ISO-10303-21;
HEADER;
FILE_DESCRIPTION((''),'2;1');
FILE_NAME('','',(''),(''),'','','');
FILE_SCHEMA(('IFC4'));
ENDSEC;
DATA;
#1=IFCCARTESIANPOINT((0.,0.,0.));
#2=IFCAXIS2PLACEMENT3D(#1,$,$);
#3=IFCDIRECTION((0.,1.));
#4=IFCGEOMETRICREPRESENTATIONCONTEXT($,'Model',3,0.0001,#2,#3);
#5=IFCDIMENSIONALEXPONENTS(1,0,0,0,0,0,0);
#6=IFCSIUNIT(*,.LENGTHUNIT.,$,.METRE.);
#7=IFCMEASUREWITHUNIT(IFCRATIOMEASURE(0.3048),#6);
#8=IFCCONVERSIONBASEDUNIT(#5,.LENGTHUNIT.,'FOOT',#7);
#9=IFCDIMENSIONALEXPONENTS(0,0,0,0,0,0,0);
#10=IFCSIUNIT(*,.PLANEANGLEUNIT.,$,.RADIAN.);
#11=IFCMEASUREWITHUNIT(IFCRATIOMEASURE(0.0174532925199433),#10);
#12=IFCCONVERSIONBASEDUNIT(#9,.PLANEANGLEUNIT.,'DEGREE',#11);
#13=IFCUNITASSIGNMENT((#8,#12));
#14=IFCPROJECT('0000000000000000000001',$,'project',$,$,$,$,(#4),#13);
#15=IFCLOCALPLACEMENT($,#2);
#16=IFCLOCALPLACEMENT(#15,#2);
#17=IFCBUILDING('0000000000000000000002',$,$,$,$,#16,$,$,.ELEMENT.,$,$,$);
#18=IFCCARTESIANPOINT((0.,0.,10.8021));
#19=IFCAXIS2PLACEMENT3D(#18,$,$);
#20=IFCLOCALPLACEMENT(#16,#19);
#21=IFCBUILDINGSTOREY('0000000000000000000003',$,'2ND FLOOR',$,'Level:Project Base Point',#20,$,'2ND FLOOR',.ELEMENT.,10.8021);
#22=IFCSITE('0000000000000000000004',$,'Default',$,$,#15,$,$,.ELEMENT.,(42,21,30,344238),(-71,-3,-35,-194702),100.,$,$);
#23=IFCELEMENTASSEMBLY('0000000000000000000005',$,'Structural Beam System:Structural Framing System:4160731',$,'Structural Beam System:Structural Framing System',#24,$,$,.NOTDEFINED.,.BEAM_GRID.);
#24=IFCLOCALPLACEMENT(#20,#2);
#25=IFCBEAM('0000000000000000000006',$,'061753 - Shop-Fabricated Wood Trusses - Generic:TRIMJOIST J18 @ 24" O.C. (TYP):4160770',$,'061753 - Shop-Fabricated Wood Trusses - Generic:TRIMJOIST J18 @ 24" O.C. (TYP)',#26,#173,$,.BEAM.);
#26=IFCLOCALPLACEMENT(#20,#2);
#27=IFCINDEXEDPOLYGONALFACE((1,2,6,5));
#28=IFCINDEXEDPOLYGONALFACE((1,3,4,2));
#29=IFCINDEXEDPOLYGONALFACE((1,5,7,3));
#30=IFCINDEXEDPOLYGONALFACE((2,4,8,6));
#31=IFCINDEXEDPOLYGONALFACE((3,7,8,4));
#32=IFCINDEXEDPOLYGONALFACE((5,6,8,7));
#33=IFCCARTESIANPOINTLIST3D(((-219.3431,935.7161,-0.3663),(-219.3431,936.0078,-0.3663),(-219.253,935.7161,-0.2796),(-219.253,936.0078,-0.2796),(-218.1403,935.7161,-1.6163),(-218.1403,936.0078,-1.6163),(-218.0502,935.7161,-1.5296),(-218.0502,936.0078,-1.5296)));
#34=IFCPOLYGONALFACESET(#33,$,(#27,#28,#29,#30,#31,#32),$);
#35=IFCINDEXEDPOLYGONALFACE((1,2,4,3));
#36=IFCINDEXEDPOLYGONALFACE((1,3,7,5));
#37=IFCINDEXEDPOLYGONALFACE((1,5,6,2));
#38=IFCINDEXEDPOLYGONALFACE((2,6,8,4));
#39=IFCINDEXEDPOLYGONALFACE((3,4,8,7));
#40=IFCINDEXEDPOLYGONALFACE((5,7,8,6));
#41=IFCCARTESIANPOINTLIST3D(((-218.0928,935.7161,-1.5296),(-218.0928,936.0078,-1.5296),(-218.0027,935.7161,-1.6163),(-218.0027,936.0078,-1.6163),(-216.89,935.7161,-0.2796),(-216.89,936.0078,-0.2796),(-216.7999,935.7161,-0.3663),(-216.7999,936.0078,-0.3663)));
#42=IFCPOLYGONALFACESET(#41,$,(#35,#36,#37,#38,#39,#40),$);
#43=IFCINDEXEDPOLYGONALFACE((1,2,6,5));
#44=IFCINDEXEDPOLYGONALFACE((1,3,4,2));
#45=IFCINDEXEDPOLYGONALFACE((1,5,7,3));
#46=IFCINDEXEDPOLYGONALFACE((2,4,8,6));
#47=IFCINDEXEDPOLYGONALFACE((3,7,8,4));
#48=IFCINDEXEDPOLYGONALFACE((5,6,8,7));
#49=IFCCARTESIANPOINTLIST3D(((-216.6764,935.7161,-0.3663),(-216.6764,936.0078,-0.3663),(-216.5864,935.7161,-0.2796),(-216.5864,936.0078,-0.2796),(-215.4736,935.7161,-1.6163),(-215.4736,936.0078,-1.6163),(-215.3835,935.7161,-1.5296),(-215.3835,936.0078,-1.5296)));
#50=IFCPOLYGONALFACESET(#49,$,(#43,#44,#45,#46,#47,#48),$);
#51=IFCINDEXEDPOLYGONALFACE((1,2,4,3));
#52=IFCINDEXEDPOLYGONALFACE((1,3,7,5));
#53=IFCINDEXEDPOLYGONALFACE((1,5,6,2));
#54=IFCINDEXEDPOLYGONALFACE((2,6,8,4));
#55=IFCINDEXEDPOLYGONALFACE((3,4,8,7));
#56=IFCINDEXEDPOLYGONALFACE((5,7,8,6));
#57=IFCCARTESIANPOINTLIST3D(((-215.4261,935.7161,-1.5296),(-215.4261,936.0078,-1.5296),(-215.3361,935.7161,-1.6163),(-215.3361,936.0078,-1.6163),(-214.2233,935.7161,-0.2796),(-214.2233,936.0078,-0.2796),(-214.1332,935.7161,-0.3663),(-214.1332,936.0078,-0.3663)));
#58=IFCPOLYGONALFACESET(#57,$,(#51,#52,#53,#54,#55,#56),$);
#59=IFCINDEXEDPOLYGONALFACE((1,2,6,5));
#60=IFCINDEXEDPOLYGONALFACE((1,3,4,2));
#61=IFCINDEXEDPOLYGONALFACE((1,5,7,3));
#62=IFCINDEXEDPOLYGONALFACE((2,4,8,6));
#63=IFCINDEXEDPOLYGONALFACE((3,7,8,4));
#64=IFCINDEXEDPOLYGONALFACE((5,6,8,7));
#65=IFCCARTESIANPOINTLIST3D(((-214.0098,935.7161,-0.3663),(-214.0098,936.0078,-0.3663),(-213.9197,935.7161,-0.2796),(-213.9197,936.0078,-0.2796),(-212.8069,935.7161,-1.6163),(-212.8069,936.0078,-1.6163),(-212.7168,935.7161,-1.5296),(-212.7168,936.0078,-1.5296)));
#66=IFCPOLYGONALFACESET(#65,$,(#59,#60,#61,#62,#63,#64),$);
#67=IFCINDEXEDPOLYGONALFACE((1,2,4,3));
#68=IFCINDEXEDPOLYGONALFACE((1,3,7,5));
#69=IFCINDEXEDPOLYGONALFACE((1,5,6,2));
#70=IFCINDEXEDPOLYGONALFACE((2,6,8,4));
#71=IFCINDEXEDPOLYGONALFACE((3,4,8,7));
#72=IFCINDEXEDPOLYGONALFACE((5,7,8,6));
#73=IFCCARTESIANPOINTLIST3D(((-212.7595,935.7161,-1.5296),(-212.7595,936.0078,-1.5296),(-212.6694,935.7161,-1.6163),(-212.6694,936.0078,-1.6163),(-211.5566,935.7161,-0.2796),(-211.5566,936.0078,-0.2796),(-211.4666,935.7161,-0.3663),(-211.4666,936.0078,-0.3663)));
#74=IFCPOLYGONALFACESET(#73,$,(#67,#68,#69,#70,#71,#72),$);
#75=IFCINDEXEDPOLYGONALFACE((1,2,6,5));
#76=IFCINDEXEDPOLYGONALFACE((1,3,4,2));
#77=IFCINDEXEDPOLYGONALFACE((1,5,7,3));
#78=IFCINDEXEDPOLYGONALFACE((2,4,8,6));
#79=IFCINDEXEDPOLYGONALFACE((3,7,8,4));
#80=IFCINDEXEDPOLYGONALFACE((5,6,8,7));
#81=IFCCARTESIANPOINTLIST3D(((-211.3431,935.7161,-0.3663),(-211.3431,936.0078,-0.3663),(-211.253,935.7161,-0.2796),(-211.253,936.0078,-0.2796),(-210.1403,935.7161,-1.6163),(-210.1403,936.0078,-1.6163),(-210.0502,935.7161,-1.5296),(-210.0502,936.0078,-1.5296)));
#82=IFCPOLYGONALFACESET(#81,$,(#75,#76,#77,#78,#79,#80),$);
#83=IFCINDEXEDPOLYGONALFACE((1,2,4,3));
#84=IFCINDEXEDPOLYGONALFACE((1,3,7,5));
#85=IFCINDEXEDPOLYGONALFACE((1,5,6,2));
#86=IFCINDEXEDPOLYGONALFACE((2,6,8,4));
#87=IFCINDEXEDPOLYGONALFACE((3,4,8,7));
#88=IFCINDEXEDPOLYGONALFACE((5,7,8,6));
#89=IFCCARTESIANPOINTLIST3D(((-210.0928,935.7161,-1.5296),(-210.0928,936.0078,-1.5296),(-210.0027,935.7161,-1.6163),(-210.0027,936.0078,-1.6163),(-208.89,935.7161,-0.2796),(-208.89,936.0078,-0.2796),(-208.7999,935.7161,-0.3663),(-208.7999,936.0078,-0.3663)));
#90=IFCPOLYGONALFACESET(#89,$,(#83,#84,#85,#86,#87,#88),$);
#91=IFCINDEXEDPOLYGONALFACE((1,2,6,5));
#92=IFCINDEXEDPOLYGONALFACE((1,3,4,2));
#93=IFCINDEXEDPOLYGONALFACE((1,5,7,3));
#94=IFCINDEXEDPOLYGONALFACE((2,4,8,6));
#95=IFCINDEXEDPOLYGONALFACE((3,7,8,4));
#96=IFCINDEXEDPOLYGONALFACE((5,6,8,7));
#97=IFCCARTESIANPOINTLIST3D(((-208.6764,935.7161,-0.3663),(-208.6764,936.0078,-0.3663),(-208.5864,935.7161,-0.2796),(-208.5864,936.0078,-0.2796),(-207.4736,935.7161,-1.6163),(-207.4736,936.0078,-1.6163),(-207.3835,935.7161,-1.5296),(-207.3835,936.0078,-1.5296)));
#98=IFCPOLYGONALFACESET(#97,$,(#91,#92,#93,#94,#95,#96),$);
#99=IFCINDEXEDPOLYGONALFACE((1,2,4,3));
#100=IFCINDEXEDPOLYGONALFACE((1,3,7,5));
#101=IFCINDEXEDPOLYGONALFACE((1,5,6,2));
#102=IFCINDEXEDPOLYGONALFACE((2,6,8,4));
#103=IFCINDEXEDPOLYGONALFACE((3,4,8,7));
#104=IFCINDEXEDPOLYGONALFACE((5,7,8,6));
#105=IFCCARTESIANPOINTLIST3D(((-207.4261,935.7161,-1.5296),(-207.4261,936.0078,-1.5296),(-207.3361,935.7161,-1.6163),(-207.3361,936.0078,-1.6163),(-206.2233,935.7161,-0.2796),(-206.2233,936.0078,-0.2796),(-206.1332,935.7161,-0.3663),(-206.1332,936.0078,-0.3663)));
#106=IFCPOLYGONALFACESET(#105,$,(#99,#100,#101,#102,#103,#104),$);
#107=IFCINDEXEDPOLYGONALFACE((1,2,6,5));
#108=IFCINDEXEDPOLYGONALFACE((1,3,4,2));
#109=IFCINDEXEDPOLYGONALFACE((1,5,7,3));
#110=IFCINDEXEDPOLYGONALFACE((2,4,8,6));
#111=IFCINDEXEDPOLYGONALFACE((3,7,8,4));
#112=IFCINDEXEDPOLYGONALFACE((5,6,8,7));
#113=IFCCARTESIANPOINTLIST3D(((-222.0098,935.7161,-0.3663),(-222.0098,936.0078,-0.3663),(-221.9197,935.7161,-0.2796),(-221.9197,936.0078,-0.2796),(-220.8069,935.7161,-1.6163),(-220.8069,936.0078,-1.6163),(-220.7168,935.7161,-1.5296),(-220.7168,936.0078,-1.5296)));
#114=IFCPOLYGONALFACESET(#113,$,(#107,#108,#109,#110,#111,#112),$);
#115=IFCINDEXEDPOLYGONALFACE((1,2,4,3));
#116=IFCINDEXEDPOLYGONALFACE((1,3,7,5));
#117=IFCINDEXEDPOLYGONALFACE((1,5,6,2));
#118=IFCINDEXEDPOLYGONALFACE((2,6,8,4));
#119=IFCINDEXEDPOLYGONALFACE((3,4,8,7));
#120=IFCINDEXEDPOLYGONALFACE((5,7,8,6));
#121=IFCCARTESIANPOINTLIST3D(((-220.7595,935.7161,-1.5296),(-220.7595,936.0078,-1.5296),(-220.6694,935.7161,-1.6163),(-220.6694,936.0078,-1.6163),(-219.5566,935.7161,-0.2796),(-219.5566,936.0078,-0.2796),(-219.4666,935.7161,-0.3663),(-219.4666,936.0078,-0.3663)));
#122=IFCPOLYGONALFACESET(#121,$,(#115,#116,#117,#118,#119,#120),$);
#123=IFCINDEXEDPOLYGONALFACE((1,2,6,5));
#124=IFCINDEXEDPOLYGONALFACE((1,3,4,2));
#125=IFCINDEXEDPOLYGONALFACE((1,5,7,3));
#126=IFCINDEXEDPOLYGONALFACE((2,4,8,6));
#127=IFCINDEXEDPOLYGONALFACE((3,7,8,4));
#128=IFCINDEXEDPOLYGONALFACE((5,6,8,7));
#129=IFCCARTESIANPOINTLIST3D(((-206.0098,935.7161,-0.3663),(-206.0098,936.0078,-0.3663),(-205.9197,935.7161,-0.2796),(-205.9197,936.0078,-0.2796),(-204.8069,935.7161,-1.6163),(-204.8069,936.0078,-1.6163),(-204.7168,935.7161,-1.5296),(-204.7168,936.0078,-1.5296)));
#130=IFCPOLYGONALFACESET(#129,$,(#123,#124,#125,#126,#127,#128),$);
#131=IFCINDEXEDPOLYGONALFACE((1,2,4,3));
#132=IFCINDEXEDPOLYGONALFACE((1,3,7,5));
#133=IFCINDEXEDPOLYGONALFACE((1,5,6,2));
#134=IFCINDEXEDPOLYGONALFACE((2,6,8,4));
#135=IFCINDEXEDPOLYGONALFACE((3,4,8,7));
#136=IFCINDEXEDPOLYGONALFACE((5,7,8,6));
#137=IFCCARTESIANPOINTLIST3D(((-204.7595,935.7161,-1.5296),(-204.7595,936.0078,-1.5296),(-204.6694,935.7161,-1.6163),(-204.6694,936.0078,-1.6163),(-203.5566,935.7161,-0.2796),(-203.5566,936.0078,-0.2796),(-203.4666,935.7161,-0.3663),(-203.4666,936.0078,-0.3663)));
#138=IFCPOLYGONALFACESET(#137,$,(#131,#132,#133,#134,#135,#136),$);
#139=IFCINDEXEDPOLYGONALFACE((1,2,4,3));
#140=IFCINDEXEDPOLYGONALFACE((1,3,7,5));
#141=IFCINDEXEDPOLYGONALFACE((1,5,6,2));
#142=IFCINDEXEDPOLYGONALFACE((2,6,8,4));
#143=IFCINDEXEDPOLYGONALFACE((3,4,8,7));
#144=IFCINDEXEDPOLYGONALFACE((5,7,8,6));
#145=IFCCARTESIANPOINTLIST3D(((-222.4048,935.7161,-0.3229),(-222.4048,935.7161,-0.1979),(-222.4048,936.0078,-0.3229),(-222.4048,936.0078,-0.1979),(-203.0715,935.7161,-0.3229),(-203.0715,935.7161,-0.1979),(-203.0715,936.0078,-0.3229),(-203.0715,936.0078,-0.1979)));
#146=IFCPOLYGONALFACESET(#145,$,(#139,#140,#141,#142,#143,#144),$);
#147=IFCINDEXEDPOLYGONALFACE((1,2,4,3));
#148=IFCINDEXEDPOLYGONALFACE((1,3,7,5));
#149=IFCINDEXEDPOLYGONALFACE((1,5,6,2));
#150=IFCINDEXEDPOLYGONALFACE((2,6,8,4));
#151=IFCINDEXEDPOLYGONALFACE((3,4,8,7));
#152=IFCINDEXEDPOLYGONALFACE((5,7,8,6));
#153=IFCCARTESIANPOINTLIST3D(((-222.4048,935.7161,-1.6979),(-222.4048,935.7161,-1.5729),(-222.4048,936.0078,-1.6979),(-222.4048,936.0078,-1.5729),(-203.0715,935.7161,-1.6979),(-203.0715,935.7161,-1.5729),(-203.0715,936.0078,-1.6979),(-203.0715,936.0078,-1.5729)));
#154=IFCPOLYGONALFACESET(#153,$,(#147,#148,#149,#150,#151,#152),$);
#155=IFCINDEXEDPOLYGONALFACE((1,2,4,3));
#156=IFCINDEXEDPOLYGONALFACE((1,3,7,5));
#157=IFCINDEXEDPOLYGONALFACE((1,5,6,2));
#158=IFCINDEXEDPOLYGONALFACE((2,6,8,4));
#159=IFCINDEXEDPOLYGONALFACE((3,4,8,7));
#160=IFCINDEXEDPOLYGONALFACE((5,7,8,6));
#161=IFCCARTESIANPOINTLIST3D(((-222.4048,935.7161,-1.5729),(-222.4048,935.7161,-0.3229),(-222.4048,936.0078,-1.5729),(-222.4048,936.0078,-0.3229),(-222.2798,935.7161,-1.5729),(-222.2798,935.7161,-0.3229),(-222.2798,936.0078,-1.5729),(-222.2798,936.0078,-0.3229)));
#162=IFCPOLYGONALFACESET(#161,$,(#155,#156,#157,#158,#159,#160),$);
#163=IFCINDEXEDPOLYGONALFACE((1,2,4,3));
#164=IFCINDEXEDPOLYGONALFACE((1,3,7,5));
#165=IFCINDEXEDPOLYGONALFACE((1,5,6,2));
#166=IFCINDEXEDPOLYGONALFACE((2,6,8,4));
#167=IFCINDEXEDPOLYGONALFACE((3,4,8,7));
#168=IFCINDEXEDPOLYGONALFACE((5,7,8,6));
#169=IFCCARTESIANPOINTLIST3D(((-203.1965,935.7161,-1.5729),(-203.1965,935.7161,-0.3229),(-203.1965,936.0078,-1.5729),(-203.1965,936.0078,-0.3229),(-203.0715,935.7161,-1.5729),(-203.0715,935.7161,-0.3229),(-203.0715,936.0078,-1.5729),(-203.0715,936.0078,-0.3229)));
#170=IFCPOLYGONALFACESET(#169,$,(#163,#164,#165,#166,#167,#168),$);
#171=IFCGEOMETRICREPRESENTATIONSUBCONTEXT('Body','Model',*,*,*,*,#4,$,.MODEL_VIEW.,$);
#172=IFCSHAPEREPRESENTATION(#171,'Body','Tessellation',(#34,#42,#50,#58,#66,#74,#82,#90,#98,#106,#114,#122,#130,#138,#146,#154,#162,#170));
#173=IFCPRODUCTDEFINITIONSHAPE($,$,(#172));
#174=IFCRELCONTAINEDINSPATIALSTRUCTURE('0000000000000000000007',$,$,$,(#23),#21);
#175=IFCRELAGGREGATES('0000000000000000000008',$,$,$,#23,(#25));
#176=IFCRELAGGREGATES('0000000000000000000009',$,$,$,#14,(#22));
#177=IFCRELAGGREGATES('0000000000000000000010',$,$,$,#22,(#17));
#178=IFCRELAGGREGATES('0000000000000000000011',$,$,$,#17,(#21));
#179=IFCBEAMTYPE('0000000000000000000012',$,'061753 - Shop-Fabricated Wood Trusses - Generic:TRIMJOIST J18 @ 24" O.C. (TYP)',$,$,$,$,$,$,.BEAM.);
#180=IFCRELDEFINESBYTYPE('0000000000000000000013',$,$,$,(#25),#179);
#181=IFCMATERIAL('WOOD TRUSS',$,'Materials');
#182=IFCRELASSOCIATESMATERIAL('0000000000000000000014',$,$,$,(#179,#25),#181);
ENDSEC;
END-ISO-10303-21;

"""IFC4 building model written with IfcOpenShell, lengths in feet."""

from ifc_helpers import new_model, entity, si_unit, converted_unit, direction, frame, frame_2d, origin, origin_2d_with_axis, place, context, subcontext, project, spatial, rectangle, extrude, source, transform, mapped, material, material_profile, profile_set, profile_usage, type_object, type_shapes, element, aggregate, save


model = new_model("IFC4")

# Units and contexts
model_context = context("Model", 3, precision=0.0001, world=origin(), true_north=direction((0.0, 1.0)))
body_context = subcontext(model_context, "Body", "Model", "MODEL_VIEW")
ifc_project = project(units=[converted_unit("LENGTHUNIT", "FOOT", entity("IfcRatioMeasure", 0.3048), si_unit("LENGTHUNIT", "METRE"), dimensions=[1, 0, 0, 0, 0, 0, 0]), converted_unit("PLANEANGLEUNIT", "DEGREE", entity("IfcRatioMeasure", 0.0174532925199433), si_unit("PLANEANGLEUNIT", "RADIAN"), dimensions=[0, 0, 0, 0, 0, 0, 0])], contexts=[model_context])

# Site, building, storey
site_placement = place(None, origin())
site = spatial("IfcSite", under=ifc_project, at=site_placement, Name="Default", CompositionType="ELEMENT", RefLatitude=(42, 21, 30, 344238), RefLongitude=(-71, -3, -35, -194702), RefElevation=100.0)
building_placement = place(site_placement, origin())
building = spatial("IfcBuilding", under=site, at=building_placement, CompositionType="ELEMENT")
storey_placement = place(building_placement, frame((0.0, 0.0, 10.8021)))
storey = spatial("IfcBuildingStorey", under=building, at=storey_placement, Name="2ND FLOOR", ObjectType="Level:Project Base Point", LongName="2ND FLOOR", CompositionType="ELEMENT", Elevation=10.8021)

# Element assembly, beam
ifc_material_1 = material(Name="WOOD TRUSS", Category="Materials")
ifc_material_profile_1 = material_profile(ifc_material_1, rectangle(XDim=1.7347, YDim=0.125, at=frame_2d((0.0, 0.0), x_axis=(1.0, 0.0))), Name="TRIMJOIST J18 @ 24\" O.C. (TYP)")
ifc_material_profile_2 = material_profile(ifc_material_1, rectangle(XDim=1.7347, YDim=0.125, at=frame_2d((0.0, 0.0), x_axis=(1.0, 0.0))), Name="TRIMJOIST J18 @ 24\" O.C. (TYP)")
ifc_material_profile_3 = material_profile(ifc_material_1, rectangle(XDim=1.7347, YDim=0.125, at=frame_2d((0.0, 0.0), x_axis=(1.0, 0.0))), Name="TRIMJOIST J18 @ 24\" O.C. (TYP)")
ifc_material_profile_4 = material_profile(ifc_material_1, rectangle(XDim=1.7347, YDim=0.125, at=frame_2d((0.0, 0.0), x_axis=(1.0, 0.0))), Name="TRIMJOIST J18 @ 24\" O.C. (TYP)")
ifc_material_profile_5 = material_profile(ifc_material_1, rectangle(XDim=1.7347, YDim=0.125, at=frame_2d((0.0, 0.0), x_axis=(1.0, 0.0))), Name="TRIMJOIST J18 @ 24\" O.C. (TYP)")
ifc_material_profile_6 = material_profile(ifc_material_1, rectangle(XDim=1.7347, YDim=0.125, at=frame_2d((0.0, 0.0), x_axis=(1.0, 0.0))), Name="TRIMJOIST J18 @ 24\" O.C. (TYP)")
ifc_material_profile_7 = material_profile(ifc_material_1, rectangle(XDim=1.7347, YDim=0.125, at=frame_2d((0.0, 0.0), x_axis=(1.0, 0.0))), Name="TRIMJOIST J18 @ 24\" O.C. (TYP)")
ifc_material_profile_8 = material_profile(ifc_material_1, rectangle(XDim=1.7347, YDim=0.125, at=frame_2d((0.0, 0.0), x_axis=(1.0, 0.0))), Name="TRIMJOIST J18 @ 24\" O.C. (TYP)")
ifc_material_profile_9 = material_profile(ifc_material_1, rectangle(XDim=1.7347, YDim=0.125, at=frame_2d((0.0, 0.0), x_axis=(1.0, 0.0))), Name="TRIMJOIST J18 @ 24\" O.C. (TYP)")
ifc_material_profile_10 = material_profile(ifc_material_1, rectangle(XDim=1.7347, YDim=0.125, at=origin_2d_with_axis()), Name="TRIMJOIST J18 @ 24\" O.C. (TYP)")
ifc_material_profile_11 = material_profile(ifc_material_1, rectangle(XDim=0.125, YDim=0.2917, at=origin_2d_with_axis()), Name="TRIMJOIST J18 @ 24\" O.C. (TYP)")
ifc_material_profile_12 = material_profile(ifc_material_1, rectangle(XDim=0.125, YDim=0.2917, at=origin_2d_with_axis()), Name="TRIMJOIST J18 @ 24\" O.C. (TYP)")
ifc_material_profile_13 = material_profile(ifc_material_1, rectangle(XDim=1.25, YDim=0.2917, at=origin_2d_with_axis()), Name="TRIMJOIST J18 @ 24\" O.C. (TYP)")
ifc_material_profile_14 = material_profile(ifc_material_1, rectangle(XDim=1.25, YDim=0.2917, at=origin_2d_with_axis()), Name="TRIMJOIST J18 @ 24\" O.C. (TYP)")
ifc_profile_set_1 = profile_set([ifc_material_profile_1, ifc_material_profile_2, ifc_material_profile_3, ifc_material_profile_4, ifc_material_profile_5, ifc_material_profile_6, ifc_material_profile_7, ifc_material_profile_8, ifc_material_profile_9, ifc_material_profile_10, ifc_material_profile_11, ifc_material_profile_12, ifc_material_profile_13, ifc_material_profile_14], Name="TRIMJOIST J18 @ 24\" O.C. (TYP)")
beam_type_1 = type_object("IfcBeamType", Name="061753 - Shop-Fabricated Wood Trusses - Generic:TRIMJOIST J18 @ 24\" O.C. (TYP)", PredefinedType="BEAM", material=ifc_profile_set_1)
shared_shape_1 = source(origin(), body_context, "Body", "SweptSolid", [
    extrude(rectangle(XDim=1.7347, YDim=0.125, at=frame_2d((0.0, 0.0), x_axis=(1.0, 0.0))), frame((5.9585, -0.1458, 0.0), z_axis=(0.0, 1.0, 0.0), x_axis=(0.693383, 0.0, 0.720569)), (0.0, 0.0, 1.0), 0.2917),
    extrude(rectangle(XDim=1.7347, YDim=0.125, at=origin_2d_with_axis()), frame((4.7082, -0.1458, 0.0), z_axis=(0.0, 1.0, 0.0), x_axis=(0.693383, 0.0, -0.720569)), (0.0, 0.0, 1.0), 0.2917),
    extrude(rectangle(XDim=1.7347, YDim=0.125, at=frame_2d((0.0, 0.0), x_axis=(1.0, 0.0))), frame((3.2918, -0.1458, 0.0), z_axis=(0.0, 1.0, 0.0), x_axis=(0.693383, 0.0, 0.720569)), (0.0, 0.0, 1.0), 0.2917),
    extrude(rectangle(XDim=1.7347, YDim=0.125, at=frame_2d((0.0, 0.0), x_axis=(1.0, 0.0))), frame((2.0415, -0.1458, 0.0), z_axis=(0.0, 1.0, 0.0), x_axis=(0.693383, 0.0, -0.720569)), (0.0, 0.0, 1.0), 0.2917),
    extrude(rectangle(XDim=1.7347, YDim=0.125, at=frame_2d((0.0, 0.0), x_axis=(1.0, 0.0))), frame((0.6251, -0.1458, 0.0), z_axis=(0.0, 1.0, 0.0), x_axis=(0.693383, 0.0, 0.720569)), (0.0, 0.0, 1.0), 0.2917),
    extrude(rectangle(XDim=1.7347, YDim=0.125, at=frame_2d((0.0, 0.0), x_axis=(1.0, 0.0))), frame((-0.6251, -0.1458, 0.0), z_axis=(0.0, 1.0, 0.0), x_axis=(0.693383, 0.0, -0.720569)), (0.0, 0.0, 1.0), 0.2917),
    extrude(rectangle(XDim=1.7347, YDim=0.125, at=frame_2d((0.0, 0.0), x_axis=(1.0, 0.0))), frame((-2.0415, -0.1458, 0.0), z_axis=(0.0, 1.0, 0.0), x_axis=(0.693383, 0.0, 0.720569)), (0.0, 0.0, 1.0), 0.2917),
    extrude(rectangle(XDim=1.7347, YDim=0.125, at=origin_2d_with_axis()), frame((-3.2918, -0.1458, 0.0), z_axis=(0.0, 1.0, 0.0), x_axis=(0.693383, 0.0, -0.720569)), (0.0, 0.0, 1.0), 0.2917),
    extrude(rectangle(XDim=1.7347, YDim=0.125, at=frame_2d((0.0, 0.0), x_axis=(1.0, 0.0))), frame((-4.7082, -0.1458, 0.0), z_axis=(0.0, 1.0, 0.0), x_axis=(0.693383, 0.0, 0.720569)), (0.0, 0.0, 1.0), 0.2917),
    extrude(rectangle(XDim=1.7347, YDim=0.125, at=frame_2d((0.0, 0.0), x_axis=(1.0, 0.0))), frame((-5.9585, -0.1458, 0.0), z_axis=(0.0, 1.0, 0.0), x_axis=(0.693383, 0.0, -0.720569)), (0.0, 0.0, 1.0), 0.2917),
    extrude(rectangle(XDim=1.7347, YDim=0.125, at=frame_2d((0.0, 0.0), x_axis=(1.0, 0.0))), frame((8.6251, -0.1458, 0.0), z_axis=(0.0, 1.0, 0.0), x_axis=(0.693383, 0.0, 0.720569)), (0.0, 0.0, 1.0), 0.2917),
    extrude(rectangle(XDim=1.7347, YDim=0.125, at=origin_2d_with_axis()), frame((7.3749, -0.1458, 0.0), z_axis=(0.0, 1.0, 0.0), x_axis=(0.693383, 0.0, -0.720569)), (0.0, 0.0, 1.0), 0.2917),
    extrude(rectangle(XDim=1.7347, YDim=0.125, at=frame_2d((0.0, 0.0), x_axis=(1.0, 0.0))), frame((-7.3749, -0.1458, 0.0), z_axis=(0.0, 1.0, 0.0), x_axis=(0.693383, 0.0, 0.720569)), (0.0, 0.0, 1.0), 0.2917),
    extrude(rectangle(XDim=1.7347, YDim=0.125, at=origin_2d_with_axis()), frame((-8.6251, -0.1458, 0.0), z_axis=(0.0, 1.0, 0.0), x_axis=(0.693383, 0.0, -0.720569)), (0.0, 0.0, 1.0), 0.2917),
    extrude(rectangle(XDim=0.125, YDim=0.2917, at=origin_2d_with_axis()), frame((-9.6667, 0.0, 0.6875), z_axis=(1.0, 0.0, 0.0), x_axis=(0.0, 0.0, -1.0)), (0.0, 0.0, 1.0), 19.3333),
    extrude(rectangle(XDim=0.125, YDim=0.2917, at=origin_2d_with_axis()), frame((-9.6667, 0.0, -0.6875), z_axis=(1.0, 0.0, 0.0), x_axis=(0.0, 0.0, -1.0)), (0.0, 0.0, 1.0), 19.3333),
    extrude(rectangle(XDim=1.25, YDim=0.2917, at=origin_2d_with_axis()), frame((9.5417, 0.0, 0.0), z_axis=(1.0, 0.0, 0.0), x_axis=(0.0, 0.0, -1.0)), (0.0, 0.0, 1.0), 0.125),
    extrude(rectangle(XDim=1.25, YDim=0.2917, at=origin_2d_with_axis()), frame((-9.6667, 0.0, 0.0), z_axis=(1.0, 0.0, 0.0), x_axis=(0.0, 0.0, -1.0)), (0.0, 0.0, 1.0), 0.125),
])
type_shapes(beam_type_1, [shared_shape_1])
assembly_1_placement = place(storey_placement, origin())
assembly_1 = element("IfcElementAssembly", 1, at=assembly_1_placement, inside=storey, Name="Structural Beam System:Structural Framing System:4160731", ObjectType="Structural Beam System:Structural Framing System", AssemblyPlace="NOTDEFINED", PredefinedType="BEAM_GRID")
ifc_profile_usage_1 = profile_usage(ifc_profile_set_1, cardinal=8)
beam_1_placement = place(assembly_1_placement, frame((-212.7382, 935.8619, -0.9479), z_axis=(0.0, 0.0, 1.0), x_axis=(-1.0, 0.0, 0.0)))
beam_1 = element("IfcBeam", 2, at=beam_1_placement, type_object=beam_type_1, material=ifc_profile_usage_1, Name="061753 - Shop-Fabricated Wood Trusses - Generic:TRIMJOIST J18 @ 24\" O.C. (TYP):4160770", ObjectType="061753 - Shop-Fabricated Wood Trusses - Generic:TRIMJOIST J18 @ 24\" O.C. (TYP)", PredefinedType="BEAM", context=body_context, shape_type="MappedRepresentation", body=[
    mapped(shared_shape_1, transform((0.0, 0.0, 0.0), scale=1.0)),
])
aggregate(assembly_1, [beam_1])

save(model, "model.ifc")
